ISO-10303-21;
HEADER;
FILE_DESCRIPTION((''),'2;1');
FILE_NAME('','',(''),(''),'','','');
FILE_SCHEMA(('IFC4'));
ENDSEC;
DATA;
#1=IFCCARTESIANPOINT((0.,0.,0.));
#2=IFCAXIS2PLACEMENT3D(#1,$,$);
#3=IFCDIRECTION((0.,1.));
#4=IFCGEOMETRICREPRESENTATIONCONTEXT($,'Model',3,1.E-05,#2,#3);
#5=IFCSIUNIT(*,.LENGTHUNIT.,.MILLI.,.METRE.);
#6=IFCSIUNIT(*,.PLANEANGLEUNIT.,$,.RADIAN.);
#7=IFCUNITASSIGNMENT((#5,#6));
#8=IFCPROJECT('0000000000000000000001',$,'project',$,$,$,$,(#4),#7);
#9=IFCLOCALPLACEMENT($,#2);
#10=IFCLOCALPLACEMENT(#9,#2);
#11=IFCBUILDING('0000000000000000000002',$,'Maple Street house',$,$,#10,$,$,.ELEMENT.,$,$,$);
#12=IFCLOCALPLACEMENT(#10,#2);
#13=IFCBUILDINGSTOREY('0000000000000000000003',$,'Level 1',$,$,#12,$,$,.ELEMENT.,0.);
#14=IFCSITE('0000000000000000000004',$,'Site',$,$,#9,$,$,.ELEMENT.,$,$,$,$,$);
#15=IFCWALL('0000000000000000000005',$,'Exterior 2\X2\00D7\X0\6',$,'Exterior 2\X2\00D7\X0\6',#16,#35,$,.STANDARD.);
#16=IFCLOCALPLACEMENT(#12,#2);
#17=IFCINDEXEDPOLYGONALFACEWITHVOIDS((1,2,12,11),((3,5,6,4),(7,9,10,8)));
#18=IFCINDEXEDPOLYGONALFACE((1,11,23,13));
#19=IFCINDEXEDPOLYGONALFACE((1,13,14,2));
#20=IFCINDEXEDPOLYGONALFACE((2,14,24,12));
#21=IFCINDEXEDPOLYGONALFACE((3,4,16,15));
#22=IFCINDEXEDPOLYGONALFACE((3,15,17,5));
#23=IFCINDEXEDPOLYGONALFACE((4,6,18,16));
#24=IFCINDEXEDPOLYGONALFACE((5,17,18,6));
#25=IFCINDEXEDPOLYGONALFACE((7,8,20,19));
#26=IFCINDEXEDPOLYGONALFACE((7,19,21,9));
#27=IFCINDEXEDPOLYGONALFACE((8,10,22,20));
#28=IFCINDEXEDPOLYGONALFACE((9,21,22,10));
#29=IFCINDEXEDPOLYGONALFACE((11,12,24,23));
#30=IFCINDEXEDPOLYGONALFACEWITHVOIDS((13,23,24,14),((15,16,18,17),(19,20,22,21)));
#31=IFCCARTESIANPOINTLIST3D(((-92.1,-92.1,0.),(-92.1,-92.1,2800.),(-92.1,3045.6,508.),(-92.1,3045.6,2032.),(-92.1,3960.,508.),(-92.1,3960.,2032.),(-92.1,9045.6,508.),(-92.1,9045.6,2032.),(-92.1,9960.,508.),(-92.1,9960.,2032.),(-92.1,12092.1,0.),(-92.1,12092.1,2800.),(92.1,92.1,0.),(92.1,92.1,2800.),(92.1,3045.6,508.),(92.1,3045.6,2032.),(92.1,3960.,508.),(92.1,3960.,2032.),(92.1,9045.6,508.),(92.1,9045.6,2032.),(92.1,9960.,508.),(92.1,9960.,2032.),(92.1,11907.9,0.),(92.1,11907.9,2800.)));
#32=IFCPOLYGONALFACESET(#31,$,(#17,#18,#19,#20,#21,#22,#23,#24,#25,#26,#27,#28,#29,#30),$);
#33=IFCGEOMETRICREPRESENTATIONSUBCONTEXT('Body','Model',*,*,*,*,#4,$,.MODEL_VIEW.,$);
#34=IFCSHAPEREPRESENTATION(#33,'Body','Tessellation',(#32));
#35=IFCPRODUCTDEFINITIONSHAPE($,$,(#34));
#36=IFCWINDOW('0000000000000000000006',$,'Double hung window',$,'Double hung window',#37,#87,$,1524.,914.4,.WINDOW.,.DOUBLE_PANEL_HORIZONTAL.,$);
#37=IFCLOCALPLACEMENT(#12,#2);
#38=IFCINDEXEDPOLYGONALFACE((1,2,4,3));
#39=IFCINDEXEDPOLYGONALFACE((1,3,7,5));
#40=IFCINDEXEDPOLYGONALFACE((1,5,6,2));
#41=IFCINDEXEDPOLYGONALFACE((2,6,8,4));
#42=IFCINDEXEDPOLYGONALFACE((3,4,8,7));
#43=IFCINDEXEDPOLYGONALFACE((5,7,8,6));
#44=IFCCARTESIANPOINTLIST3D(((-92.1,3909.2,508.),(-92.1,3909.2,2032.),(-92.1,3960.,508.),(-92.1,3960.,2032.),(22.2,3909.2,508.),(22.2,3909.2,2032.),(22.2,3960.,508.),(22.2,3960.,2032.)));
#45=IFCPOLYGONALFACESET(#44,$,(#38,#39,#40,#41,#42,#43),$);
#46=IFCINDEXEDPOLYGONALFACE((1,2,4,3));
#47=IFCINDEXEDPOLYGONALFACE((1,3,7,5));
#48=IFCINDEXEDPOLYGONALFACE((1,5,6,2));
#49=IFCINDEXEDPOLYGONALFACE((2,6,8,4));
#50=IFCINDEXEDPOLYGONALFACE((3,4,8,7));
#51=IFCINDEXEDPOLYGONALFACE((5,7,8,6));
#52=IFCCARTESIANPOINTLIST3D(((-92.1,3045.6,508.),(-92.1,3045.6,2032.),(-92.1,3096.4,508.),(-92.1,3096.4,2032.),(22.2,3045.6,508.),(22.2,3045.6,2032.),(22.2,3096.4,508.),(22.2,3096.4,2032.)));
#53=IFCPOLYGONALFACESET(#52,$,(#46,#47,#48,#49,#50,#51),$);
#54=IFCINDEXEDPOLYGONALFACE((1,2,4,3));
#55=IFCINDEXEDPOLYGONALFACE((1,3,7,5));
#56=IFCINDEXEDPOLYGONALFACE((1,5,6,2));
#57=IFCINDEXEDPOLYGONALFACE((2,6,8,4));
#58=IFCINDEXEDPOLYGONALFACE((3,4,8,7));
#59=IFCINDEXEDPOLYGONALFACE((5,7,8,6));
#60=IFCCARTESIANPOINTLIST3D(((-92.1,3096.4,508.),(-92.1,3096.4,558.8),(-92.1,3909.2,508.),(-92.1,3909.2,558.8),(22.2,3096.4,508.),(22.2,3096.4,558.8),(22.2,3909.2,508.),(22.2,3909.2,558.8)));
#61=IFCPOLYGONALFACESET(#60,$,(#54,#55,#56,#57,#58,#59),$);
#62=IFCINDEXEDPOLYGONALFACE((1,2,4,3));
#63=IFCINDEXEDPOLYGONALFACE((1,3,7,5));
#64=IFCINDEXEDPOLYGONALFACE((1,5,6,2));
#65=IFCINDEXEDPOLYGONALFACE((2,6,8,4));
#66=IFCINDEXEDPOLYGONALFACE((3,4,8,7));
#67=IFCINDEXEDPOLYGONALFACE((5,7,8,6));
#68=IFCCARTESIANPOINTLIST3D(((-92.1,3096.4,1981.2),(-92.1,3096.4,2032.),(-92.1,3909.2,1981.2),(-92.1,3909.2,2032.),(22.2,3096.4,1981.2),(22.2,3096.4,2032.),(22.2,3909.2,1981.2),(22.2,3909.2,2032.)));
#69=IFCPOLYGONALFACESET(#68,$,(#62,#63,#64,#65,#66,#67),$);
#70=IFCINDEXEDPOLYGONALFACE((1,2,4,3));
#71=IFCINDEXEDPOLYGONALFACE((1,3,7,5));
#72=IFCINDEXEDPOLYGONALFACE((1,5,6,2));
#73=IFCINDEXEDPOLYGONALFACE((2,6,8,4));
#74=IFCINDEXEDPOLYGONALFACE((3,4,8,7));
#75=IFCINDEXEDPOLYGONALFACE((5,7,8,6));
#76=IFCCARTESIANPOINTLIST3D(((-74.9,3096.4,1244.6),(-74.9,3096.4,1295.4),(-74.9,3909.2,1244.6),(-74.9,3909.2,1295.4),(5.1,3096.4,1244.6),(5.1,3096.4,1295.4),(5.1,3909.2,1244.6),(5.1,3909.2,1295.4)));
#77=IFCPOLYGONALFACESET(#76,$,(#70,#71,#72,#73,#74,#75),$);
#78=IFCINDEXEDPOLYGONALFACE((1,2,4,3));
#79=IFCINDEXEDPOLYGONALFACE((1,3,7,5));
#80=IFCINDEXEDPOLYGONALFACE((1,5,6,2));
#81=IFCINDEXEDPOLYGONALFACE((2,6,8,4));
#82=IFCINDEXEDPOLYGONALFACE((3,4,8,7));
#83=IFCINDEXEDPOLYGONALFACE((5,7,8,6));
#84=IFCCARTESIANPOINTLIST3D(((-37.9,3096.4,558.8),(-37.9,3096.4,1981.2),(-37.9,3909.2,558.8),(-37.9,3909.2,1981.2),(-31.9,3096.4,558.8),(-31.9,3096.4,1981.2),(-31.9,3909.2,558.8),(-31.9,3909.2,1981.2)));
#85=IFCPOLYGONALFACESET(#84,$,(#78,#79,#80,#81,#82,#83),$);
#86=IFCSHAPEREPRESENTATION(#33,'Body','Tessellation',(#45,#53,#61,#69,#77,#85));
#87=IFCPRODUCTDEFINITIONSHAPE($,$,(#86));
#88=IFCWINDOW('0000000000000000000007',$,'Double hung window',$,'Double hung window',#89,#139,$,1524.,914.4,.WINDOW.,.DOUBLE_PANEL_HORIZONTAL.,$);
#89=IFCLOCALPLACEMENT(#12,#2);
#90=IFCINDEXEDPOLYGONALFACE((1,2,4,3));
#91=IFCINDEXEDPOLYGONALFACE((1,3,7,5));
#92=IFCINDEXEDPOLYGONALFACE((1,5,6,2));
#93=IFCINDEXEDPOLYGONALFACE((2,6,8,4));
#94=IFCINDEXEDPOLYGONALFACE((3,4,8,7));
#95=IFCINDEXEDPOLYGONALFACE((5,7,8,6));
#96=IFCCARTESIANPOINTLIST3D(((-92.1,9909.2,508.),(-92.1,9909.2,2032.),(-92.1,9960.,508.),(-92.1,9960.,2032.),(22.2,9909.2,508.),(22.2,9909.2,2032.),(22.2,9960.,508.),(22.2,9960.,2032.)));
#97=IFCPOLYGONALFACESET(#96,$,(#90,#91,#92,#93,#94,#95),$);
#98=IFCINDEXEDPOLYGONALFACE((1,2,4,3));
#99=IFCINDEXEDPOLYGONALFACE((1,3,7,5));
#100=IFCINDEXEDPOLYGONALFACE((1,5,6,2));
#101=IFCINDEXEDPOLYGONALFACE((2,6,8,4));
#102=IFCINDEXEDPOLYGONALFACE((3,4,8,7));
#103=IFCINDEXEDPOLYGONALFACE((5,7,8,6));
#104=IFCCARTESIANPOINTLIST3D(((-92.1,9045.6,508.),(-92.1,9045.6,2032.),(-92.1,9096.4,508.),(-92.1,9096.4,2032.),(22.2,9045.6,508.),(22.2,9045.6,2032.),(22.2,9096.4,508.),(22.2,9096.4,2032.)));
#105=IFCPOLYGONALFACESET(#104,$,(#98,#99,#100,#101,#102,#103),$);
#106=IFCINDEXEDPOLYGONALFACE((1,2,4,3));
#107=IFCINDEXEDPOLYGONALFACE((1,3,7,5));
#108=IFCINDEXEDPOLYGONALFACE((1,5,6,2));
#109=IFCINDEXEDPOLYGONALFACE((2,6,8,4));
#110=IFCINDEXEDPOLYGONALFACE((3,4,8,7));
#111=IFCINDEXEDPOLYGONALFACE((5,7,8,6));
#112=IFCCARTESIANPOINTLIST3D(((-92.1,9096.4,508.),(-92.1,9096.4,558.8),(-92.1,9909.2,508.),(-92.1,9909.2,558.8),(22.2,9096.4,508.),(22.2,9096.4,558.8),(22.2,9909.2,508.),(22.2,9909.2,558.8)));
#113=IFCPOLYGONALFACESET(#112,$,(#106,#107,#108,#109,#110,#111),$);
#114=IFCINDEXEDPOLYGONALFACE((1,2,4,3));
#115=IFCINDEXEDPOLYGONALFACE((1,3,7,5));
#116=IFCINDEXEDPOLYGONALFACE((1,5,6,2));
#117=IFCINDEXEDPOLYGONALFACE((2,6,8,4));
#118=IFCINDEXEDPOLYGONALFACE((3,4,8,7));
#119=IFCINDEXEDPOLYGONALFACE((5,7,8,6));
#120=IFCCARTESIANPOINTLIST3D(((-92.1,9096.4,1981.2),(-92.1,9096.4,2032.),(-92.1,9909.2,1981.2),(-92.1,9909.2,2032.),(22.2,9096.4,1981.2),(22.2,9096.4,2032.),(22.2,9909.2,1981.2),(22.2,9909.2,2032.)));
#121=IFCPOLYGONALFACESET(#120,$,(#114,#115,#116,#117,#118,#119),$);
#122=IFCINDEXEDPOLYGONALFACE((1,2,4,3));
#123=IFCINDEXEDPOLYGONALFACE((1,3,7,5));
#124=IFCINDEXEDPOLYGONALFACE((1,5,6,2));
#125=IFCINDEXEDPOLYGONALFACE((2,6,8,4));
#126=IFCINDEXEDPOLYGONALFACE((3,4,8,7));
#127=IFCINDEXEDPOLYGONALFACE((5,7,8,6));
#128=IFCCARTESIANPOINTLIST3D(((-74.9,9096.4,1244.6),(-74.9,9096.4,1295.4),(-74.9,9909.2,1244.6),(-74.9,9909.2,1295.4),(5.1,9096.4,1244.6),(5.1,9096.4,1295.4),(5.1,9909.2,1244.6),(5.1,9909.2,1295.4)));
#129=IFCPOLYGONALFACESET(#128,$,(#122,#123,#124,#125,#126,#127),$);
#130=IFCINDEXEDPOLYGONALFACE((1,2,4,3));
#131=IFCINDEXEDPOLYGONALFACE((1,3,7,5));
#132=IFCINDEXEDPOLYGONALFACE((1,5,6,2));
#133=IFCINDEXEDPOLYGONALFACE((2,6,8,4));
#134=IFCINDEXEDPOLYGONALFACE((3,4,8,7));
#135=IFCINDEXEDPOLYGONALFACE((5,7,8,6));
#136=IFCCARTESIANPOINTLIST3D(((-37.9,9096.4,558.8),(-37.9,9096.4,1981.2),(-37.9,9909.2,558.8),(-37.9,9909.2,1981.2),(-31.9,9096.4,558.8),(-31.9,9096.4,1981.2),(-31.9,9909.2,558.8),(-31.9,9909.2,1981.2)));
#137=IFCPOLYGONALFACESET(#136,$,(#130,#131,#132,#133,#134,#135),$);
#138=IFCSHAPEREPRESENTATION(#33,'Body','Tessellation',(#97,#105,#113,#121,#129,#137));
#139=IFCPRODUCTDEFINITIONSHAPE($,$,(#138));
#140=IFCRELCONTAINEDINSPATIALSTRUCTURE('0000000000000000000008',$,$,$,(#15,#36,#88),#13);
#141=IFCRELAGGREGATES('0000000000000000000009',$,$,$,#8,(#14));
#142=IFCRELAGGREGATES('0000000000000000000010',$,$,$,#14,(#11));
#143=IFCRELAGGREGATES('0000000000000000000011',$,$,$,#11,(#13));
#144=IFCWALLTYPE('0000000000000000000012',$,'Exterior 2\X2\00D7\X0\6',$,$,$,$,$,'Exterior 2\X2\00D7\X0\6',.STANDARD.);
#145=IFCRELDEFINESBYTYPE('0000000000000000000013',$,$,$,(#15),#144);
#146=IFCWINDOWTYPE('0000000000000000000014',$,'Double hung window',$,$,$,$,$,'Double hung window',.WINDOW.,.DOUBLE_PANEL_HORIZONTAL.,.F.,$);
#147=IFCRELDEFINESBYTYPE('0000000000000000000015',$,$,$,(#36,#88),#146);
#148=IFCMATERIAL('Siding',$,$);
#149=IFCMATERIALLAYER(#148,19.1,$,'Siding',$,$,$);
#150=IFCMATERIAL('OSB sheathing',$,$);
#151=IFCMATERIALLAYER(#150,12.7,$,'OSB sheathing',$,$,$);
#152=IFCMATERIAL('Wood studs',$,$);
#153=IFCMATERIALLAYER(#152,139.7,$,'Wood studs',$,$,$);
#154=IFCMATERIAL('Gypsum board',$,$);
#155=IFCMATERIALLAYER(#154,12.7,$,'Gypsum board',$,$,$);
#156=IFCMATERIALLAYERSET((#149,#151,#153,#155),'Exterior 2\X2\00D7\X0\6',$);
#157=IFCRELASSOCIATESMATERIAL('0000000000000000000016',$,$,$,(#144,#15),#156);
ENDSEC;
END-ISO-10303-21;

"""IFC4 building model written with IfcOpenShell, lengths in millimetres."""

from ifc_helpers import new_model, si_unit, direction, frame, origin, origin_with_axes, place, context, subcontext, project, spatial, polyline, outline, extrude, material, layer, layer_set, layer_usage, type_object, element, fill, save


model = new_model("IFC4")

# Units and contexts
model_context = context("Model", 3, precision=1e-05, world=origin(), true_north=direction((0.0, 1.0)))
body_context = subcontext(model_context, "Body", "Model", "MODEL_VIEW")
ifc_project = project(units=[si_unit("LENGTHUNIT", "METRE", prefix="MILLI"), si_unit("PLANEANGLEUNIT", "RADIAN")], contexts=[model_context])

# Site, building, storey
site_placement = place(None, origin())
site = spatial("IfcSite", under=ifc_project, at=site_placement, Name="Site", CompositionType="ELEMENT")
building_placement = place(site_placement, origin())
building = spatial("IfcBuilding", under=site, at=building_placement, Name="Maple Street house", CompositionType="ELEMENT")
storey_placement = place(building_placement, origin())
storey = spatial("IfcBuildingStorey", under=building, at=storey_placement, Name="Level 1", CompositionType="ELEMENT", Elevation=0.0)

# Shared definitions
ifc_material_1 = material(Name="Siding")
ifc_layer_1 = layer(ifc_material_1, 19.1, Name="Siding")
ifc_material_2 = material(Name="OSB sheathing")
ifc_layer_2 = layer(ifc_material_2, 12.7, Name="OSB sheathing")
ifc_material_3 = material(Name="Wood studs")
ifc_layer_3 = layer(ifc_material_3, 139.7, Name="Wood studs")
ifc_material_4 = material(Name="Gypsum board")
ifc_layer_4 = layer(ifc_material_4, 12.7, Name="Gypsum board")
ifc_layer_set_1 = layer_set([ifc_layer_1, ifc_layer_2, ifc_layer_3, ifc_layer_4], Name="Exterior 2×6")
wall_type_1 = type_object("IfcWallType", Name="Exterior 2×6", ElementType="Exterior 2×6", PredefinedType="STANDARD", material=ifc_layer_set_1)

# Shared definitions
window_type = type_object("IfcWindowType", Name="Double hung window", ElementType="Double hung window", ParameterTakesPrecedence=False, PartitioningType="DOUBLE_PANEL_HORIZONTAL", PredefinedType="WINDOW")

# Wall, openings, windows
ifc_layer_usage_1 = layer_usage(ifc_layer_set_1, "AXIS2", "POSITIVE", -92.1)
wall_1_placement = place(storey_placement, frame((0.0, 12000.0, 0.0), z_axis=(0.0, 0.0, 1.0), x_axis=(0.0, -1.0, 0.0)))
wall_1 = element("IfcWall", 1, at=wall_1_placement, inside=storey, type_object=wall_type_1, material=ifc_layer_usage_1, Name="Exterior 2×6", ObjectType="Exterior 2×6", PredefinedType="STANDARD", context=body_context, shape_type="SweptSolid", body=[
    extrude(outline(polyline([(-92.1, -92.1), (12092.1, -92.1), (11907.9, 92.1), (92.1, 92.1), (-92.1, -92.1)])), origin(), (0.0, 0.0, 1.0), 2800.0),
])
opening_1_placement = place(wall_1_placement, frame((8040.0, 0.0, 508.0), z_axis=(0.0, 0.0, 1.0), x_axis=(1.0, 0.0, 0.0)))
opening_1 = element("IfcOpeningElement", 2, at=opening_1_placement, cuts=wall_1, PredefinedType="OPENING", context=body_context, shape_type="SweptSolid", body=[
    extrude(outline(polyline([(0.0, -102.1), (914.4, -102.1), (914.4, 102.1), (0.0, 102.1), (0.0, -102.1)])), origin(), (0.0, 0.0, 1.0), 1524.0),
])
opening_2_placement = place(wall_1_placement, frame((2040.0, 0.0, 508.0), z_axis=(0.0, 0.0, 1.0), x_axis=(1.0, 0.0, 0.0)))
opening_2 = element("IfcOpeningElement", 3, at=opening_2_placement, cuts=wall_1, PredefinedType="OPENING", context=body_context, shape_type="SweptSolid", body=[
    extrude(outline(polyline([(0.0, -102.1), (914.4, -102.1), (914.4, 102.1), (0.0, 102.1), (0.0, -102.1)])), origin(), (0.0, 0.0, 1.0), 1524.0),
])
window_1_placement = place(opening_1_placement, origin_with_axes())
window_1 = element("IfcWindow", 4, at=window_1_placement, inside=storey, type_object=window_type, Name="Double hung window", ObjectType="Double hung window", OverallHeight=1524.0, OverallWidth=914.4, PartitioningType="DOUBLE_PANEL_HORIZONTAL", PredefinedType="WINDOW", context=body_context, shape_type="SweptSolid", body=[
    extrude(outline(polyline([(0.0, -92.1), (50.8, -92.1), (50.8, 22.2), (0.0, 22.2), (0.0, -92.1)])), origin(), (0.0, 0.0, 1.0), 1524.0),
    extrude(outline(polyline([(863.6, -92.1), (914.4, -92.1), (914.4, 22.2), (863.6, 22.2), (863.6, -92.1)])), origin(), (0.0, 0.0, 1.0), 1524.0),
    extrude(outline(polyline([(50.8, -92.1), (863.6, -92.1), (863.6, 22.2), (50.8, 22.2), (50.8, -92.1)])), origin(), (0.0, 0.0, 1.0), 50.8),
    extrude(outline(polyline([(50.8, -92.1), (863.6, -92.1), (863.6, 22.2), (50.8, 22.2), (50.8, -92.1)])), frame((0.0, 0.0, 1473.2)), (0.0, 0.0, 1.0), 50.8),
    extrude(outline(polyline([(50.8, -74.9), (863.6, -74.9), (863.6, 5.1), (50.8, 5.1), (50.8, -74.9)])), frame((0.0, 0.0, 736.6)), (0.0, 0.0, 1.0), 50.8),
    extrude(outline(polyline([(50.8, -37.9), (863.6, -37.9), (863.6, -31.9), (50.8, -31.9), (50.8, -37.9)])), frame((0.0, 0.0, 50.8)), (0.0, 0.0, 1.0), 1422.4),
])
fill(opening_1, window_1)
window_2_placement = place(opening_2_placement, origin_with_axes())
window_2 = element("IfcWindow", 5, at=window_2_placement, inside=storey, type_object=window_type, Name="Double hung window", ObjectType="Double hung window", OverallHeight=1524.0, OverallWidth=914.4, PartitioningType="DOUBLE_PANEL_HORIZONTAL", PredefinedType="WINDOW", context=body_context, shape_type="SweptSolid", body=[
    extrude(outline(polyline([(0.0, -92.1), (50.8, -92.1), (50.8, 22.2), (0.0, 22.2), (0.0, -92.1)])), origin(), (0.0, 0.0, 1.0), 1524.0),
    extrude(outline(polyline([(863.6, -92.1), (914.4, -92.1), (914.4, 22.2), (863.6, 22.2), (863.6, -92.1)])), origin(), (0.0, 0.0, 1.0), 1524.0),
    extrude(outline(polyline([(50.8, -92.1), (863.6, -92.1), (863.6, 22.2), (50.8, 22.2), (50.8, -92.1)])), origin(), (0.0, 0.0, 1.0), 50.8),
    extrude(outline(polyline([(50.8, -92.1), (863.6, -92.1), (863.6, 22.2), (50.8, 22.2), (50.8, -92.1)])), frame((0.0, 0.0, 1473.2)), (0.0, 0.0, 1.0), 50.8),
    extrude(outline(polyline([(50.8, -74.9), (863.6, -74.9), (863.6, 5.1), (50.8, 5.1), (50.8, -74.9)])), frame((0.0, 0.0, 736.6)), (0.0, 0.0, 1.0), 50.8),
    extrude(outline(polyline([(50.8, -37.9), (863.6, -37.9), (863.6, -31.9), (50.8, -31.9), (50.8, -37.9)])), frame((0.0, 0.0, 50.8)), (0.0, 0.0, 1.0), 1422.4),
])
fill(opening_2, window_2)

save(model, "model.ifc")
